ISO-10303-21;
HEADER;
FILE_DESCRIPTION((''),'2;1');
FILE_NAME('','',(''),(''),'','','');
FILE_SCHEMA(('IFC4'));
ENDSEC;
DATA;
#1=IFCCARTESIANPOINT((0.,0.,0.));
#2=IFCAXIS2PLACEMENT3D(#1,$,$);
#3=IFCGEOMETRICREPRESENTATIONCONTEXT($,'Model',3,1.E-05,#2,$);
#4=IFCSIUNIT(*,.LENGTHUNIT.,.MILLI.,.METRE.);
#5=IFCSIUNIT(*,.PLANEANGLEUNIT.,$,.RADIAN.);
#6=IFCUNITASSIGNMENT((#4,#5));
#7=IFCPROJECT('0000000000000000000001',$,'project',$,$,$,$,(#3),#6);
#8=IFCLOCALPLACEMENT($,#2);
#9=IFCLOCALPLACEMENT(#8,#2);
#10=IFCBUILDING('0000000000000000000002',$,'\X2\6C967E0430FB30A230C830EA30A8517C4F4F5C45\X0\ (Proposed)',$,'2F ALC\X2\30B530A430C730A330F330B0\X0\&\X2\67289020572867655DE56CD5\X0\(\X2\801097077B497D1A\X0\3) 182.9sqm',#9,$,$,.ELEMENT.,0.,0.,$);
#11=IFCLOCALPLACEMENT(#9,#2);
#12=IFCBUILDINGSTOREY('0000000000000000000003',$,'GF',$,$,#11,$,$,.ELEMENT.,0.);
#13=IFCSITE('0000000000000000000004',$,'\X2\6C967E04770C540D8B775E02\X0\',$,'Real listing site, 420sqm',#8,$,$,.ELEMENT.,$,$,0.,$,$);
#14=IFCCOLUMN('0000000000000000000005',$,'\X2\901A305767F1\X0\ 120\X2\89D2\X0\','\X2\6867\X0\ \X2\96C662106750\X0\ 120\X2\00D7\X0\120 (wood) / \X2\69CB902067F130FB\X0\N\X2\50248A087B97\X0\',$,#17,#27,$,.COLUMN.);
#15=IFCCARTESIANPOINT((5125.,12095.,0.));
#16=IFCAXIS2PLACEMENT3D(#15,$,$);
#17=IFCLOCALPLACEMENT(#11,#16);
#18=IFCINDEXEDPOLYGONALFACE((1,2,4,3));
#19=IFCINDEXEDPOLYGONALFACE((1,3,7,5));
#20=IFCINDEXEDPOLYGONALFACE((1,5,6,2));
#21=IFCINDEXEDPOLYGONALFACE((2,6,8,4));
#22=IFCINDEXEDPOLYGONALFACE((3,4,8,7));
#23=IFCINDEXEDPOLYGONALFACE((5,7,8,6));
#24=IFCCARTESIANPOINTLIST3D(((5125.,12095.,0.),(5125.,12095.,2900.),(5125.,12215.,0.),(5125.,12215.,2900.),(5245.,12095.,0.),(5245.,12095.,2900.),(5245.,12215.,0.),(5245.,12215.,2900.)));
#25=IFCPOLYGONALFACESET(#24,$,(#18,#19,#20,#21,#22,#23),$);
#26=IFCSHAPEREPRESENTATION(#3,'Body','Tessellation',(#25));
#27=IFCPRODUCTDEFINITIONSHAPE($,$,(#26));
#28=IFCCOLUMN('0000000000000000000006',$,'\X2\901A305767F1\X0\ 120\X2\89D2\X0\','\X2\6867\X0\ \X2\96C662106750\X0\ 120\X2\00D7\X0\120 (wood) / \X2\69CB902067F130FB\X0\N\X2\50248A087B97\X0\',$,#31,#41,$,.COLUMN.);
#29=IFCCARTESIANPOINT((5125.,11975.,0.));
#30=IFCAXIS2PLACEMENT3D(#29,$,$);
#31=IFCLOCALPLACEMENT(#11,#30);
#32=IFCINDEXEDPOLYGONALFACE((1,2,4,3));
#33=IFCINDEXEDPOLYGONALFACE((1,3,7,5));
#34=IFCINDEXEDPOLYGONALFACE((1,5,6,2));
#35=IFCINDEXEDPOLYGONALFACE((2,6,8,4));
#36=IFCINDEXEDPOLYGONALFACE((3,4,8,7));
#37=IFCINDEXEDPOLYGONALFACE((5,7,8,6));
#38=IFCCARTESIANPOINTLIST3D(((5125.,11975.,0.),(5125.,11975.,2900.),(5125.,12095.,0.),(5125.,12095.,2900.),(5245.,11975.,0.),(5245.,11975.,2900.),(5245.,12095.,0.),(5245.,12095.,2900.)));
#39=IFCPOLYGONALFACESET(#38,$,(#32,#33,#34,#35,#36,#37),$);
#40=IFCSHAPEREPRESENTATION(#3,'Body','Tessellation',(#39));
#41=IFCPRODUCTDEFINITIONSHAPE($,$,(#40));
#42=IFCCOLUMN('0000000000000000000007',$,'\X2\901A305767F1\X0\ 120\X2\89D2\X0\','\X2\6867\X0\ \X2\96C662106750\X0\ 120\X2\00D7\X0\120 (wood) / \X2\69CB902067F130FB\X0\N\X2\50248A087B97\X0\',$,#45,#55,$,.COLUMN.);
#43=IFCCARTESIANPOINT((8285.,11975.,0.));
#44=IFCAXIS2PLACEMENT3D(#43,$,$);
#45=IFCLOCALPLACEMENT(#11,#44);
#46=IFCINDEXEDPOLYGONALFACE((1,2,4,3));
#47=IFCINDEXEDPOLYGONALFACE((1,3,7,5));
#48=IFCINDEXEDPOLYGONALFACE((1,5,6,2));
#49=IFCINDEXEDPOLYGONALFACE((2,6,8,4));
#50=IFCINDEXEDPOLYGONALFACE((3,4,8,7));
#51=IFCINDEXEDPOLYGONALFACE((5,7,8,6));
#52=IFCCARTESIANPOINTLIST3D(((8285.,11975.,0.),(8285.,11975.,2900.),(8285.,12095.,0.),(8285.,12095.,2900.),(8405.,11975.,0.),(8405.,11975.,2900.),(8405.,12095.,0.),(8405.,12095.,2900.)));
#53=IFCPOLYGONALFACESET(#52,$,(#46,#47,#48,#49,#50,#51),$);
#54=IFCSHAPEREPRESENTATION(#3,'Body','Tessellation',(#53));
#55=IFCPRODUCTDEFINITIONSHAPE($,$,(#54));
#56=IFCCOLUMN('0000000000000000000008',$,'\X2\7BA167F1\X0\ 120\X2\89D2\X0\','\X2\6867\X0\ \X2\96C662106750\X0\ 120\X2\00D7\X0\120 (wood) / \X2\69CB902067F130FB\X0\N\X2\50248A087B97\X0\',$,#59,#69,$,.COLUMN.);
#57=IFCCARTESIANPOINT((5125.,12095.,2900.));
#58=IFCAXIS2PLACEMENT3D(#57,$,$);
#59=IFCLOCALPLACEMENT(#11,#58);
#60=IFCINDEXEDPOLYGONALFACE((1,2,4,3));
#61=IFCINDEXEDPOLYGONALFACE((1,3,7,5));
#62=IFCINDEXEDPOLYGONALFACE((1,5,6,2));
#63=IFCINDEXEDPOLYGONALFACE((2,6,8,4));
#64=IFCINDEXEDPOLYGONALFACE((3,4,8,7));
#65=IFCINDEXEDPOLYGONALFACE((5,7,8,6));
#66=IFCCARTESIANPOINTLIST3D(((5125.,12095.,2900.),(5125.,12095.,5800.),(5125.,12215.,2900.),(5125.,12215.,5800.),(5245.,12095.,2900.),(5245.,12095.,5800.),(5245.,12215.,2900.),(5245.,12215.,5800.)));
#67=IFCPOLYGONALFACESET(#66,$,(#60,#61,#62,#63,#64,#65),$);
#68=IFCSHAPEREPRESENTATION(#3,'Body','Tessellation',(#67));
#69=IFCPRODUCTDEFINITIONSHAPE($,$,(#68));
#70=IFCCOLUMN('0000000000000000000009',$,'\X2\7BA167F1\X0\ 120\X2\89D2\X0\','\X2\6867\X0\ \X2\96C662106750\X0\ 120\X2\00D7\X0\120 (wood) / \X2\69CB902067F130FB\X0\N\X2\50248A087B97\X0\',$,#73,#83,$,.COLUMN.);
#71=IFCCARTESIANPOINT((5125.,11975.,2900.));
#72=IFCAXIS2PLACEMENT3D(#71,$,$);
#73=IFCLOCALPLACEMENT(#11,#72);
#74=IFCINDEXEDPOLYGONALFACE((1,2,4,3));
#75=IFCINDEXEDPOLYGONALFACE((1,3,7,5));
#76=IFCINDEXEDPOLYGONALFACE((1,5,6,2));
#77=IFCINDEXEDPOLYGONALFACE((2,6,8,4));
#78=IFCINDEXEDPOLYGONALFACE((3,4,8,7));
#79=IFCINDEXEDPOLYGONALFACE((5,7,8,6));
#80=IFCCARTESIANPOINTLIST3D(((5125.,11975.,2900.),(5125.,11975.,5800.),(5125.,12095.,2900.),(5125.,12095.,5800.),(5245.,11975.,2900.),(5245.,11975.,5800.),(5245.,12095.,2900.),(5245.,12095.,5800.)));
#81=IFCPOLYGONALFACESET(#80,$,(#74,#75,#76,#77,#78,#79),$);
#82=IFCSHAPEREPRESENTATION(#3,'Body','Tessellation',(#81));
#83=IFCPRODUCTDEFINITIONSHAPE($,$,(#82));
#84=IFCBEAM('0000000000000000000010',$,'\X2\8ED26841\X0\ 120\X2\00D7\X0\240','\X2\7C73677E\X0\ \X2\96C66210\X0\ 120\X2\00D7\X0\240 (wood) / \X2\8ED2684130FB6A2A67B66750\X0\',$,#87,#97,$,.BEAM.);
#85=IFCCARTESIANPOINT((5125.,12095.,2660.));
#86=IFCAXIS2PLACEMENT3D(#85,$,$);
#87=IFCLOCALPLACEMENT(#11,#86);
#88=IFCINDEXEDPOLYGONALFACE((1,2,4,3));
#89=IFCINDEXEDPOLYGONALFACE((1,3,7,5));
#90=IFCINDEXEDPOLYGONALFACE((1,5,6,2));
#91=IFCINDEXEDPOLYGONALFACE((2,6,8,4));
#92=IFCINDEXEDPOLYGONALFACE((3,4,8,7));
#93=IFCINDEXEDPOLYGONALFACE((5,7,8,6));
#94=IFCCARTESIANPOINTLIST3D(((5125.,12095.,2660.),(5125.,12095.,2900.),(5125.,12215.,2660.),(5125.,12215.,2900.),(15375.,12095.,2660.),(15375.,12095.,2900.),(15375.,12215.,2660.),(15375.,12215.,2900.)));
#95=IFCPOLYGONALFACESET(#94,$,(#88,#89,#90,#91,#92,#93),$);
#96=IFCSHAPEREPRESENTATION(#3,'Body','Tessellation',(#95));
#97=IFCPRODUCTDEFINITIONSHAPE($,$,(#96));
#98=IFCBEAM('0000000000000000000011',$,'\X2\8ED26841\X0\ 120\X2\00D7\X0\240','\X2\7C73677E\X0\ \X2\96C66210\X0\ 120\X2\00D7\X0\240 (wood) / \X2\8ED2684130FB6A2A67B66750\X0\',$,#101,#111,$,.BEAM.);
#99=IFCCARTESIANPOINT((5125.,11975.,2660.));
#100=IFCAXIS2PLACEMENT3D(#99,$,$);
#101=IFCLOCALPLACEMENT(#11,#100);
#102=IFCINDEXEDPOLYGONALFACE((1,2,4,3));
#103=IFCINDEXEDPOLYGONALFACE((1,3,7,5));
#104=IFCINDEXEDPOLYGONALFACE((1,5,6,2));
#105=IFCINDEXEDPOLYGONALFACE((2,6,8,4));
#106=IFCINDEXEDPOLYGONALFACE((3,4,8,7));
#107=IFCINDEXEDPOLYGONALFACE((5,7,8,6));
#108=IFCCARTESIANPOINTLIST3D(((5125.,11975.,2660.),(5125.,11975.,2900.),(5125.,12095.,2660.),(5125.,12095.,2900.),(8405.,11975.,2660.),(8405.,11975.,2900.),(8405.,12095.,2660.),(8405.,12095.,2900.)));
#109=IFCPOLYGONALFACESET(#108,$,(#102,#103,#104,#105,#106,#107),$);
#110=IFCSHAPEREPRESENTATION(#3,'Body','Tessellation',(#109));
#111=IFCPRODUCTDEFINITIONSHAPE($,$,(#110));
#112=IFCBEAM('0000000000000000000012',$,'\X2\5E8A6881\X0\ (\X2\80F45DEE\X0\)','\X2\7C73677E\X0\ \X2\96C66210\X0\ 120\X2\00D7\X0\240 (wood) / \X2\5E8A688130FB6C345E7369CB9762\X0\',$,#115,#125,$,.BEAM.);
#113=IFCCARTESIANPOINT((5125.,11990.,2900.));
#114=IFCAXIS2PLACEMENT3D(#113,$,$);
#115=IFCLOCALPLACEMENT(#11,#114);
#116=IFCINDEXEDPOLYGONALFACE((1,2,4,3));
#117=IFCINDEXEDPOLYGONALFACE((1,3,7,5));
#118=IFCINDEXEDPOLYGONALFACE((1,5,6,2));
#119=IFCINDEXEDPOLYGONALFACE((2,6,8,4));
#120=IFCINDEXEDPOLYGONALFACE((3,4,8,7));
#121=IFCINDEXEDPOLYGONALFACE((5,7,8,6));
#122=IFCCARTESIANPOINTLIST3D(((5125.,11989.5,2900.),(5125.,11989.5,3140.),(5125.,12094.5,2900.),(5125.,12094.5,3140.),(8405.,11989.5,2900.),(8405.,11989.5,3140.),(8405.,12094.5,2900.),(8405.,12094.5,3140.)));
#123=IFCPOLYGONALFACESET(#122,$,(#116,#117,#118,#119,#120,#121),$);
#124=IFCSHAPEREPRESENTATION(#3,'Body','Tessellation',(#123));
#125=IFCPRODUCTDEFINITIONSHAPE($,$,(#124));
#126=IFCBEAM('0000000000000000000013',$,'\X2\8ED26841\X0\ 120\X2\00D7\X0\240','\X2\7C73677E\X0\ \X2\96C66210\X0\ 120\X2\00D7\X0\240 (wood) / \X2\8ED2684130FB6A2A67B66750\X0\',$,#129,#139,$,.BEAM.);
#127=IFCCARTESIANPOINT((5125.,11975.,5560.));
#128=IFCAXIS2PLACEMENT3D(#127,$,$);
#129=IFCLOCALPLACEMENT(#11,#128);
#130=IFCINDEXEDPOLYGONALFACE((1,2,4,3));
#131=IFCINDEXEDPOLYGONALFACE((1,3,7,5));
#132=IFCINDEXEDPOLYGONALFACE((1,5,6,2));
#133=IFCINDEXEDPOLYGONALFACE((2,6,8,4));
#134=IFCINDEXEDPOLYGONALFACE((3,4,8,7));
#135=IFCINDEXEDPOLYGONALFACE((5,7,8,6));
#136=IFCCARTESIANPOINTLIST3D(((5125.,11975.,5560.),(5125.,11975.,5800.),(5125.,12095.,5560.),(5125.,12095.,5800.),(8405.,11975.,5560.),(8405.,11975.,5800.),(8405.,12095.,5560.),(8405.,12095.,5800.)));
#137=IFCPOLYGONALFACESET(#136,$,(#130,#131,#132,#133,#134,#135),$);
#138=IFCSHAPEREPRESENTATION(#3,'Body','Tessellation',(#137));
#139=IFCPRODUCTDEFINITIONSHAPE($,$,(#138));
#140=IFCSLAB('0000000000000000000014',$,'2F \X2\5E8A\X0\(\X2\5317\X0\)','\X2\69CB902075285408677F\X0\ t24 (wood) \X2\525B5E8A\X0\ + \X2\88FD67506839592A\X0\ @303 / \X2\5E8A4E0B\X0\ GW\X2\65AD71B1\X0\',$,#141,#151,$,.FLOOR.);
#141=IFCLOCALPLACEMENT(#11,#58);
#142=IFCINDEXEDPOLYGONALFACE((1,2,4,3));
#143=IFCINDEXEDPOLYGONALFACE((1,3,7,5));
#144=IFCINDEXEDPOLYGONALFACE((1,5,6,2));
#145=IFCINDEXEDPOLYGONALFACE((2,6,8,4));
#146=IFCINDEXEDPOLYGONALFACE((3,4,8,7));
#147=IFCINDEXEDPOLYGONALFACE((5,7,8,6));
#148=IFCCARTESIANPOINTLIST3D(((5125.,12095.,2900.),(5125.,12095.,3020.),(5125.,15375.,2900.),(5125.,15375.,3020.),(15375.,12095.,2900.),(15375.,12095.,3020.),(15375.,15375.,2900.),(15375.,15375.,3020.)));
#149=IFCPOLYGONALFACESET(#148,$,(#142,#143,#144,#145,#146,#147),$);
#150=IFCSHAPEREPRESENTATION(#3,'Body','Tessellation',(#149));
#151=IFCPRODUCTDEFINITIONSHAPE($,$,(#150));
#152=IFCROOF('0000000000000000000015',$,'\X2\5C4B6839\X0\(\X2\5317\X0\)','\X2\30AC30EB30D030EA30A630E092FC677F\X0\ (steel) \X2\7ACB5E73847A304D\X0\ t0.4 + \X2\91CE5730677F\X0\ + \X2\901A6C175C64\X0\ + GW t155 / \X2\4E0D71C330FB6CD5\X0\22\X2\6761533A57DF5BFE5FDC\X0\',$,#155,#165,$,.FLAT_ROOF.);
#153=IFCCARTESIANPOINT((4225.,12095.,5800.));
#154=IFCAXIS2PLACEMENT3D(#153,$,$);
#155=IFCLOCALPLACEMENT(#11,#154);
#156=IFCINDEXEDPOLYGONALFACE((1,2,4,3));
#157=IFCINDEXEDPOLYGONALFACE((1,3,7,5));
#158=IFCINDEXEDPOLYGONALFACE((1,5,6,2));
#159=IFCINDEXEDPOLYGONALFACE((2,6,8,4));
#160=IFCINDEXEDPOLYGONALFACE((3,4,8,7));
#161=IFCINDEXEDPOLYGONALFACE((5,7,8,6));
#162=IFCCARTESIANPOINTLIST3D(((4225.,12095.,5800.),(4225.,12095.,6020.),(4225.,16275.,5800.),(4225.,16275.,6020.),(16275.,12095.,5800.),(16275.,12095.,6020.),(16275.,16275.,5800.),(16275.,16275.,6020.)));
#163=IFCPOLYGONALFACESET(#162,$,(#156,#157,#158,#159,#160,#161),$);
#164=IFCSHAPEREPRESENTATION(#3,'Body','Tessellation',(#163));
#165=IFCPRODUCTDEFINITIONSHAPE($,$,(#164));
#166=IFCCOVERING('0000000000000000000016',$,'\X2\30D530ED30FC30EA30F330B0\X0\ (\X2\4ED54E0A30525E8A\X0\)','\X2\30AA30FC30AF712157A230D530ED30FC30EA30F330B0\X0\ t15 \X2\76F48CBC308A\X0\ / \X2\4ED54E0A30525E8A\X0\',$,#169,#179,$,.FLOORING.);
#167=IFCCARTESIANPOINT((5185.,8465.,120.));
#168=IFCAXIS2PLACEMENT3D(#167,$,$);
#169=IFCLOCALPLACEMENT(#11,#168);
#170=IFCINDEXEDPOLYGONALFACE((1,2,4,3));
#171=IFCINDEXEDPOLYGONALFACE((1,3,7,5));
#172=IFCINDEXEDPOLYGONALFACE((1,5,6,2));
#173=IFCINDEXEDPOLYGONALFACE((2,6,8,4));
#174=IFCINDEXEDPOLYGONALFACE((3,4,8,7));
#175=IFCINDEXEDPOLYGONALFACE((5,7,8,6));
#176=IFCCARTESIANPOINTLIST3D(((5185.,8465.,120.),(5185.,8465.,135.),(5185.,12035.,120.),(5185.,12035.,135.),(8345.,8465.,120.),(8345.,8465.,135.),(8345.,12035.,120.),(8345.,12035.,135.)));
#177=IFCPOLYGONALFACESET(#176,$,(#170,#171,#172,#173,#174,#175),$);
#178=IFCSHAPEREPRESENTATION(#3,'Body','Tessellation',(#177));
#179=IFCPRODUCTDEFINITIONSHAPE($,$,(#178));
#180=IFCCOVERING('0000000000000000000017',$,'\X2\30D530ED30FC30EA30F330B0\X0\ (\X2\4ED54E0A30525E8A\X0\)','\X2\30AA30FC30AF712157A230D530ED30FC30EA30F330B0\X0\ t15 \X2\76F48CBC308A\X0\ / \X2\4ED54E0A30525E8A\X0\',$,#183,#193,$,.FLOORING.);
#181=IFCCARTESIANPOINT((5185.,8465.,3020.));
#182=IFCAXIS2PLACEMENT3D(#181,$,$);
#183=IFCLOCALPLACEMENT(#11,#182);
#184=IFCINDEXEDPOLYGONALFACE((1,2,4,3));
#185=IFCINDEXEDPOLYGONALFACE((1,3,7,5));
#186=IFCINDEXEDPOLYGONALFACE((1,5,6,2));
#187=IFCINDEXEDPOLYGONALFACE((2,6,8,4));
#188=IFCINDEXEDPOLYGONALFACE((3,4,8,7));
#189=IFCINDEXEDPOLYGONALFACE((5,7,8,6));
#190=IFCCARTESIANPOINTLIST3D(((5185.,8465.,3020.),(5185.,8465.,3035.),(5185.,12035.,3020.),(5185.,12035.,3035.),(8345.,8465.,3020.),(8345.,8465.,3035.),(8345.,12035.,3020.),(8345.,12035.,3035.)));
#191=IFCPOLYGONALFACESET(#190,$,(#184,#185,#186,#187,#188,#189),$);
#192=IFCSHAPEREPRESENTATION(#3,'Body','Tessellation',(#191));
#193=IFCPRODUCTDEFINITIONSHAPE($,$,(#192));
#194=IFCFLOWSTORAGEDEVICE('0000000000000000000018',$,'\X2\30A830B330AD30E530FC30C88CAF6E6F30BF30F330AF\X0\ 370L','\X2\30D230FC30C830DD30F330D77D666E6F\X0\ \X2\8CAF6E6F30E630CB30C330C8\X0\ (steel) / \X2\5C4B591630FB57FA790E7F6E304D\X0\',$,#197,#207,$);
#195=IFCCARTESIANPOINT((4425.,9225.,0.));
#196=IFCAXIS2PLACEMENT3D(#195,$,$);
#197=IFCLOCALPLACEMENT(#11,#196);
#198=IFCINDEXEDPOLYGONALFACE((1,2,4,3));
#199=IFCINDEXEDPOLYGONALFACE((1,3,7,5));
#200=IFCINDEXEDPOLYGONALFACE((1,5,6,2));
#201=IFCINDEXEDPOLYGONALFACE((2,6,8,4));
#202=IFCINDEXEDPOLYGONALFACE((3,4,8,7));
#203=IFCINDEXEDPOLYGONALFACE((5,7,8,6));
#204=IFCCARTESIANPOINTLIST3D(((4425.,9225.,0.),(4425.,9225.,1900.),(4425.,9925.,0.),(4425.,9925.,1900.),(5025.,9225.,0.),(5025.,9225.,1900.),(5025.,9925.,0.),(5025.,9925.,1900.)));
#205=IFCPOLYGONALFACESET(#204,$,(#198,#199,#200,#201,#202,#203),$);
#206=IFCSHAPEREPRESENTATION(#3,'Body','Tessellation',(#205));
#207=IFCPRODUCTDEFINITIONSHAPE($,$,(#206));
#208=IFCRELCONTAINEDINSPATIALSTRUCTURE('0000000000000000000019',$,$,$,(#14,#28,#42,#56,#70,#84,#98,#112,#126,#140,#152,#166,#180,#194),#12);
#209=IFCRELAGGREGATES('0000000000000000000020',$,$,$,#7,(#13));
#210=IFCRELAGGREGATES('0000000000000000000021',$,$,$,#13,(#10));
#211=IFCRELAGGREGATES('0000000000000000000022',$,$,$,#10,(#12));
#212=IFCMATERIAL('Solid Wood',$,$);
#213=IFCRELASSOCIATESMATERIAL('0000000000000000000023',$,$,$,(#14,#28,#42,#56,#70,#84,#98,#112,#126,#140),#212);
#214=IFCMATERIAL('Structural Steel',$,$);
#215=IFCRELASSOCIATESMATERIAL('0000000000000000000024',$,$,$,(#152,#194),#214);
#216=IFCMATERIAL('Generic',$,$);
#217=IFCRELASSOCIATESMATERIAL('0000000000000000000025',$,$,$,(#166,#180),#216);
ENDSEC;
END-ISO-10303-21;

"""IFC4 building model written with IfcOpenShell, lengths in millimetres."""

from ifc_helpers import new_model, si_unit, frame, frame_2d, origin, place, context, project, spatial, rectangle, extrude, material, element, save


model = new_model("IFC4")

# Units and contexts
model_context = context("Model", 3, precision=1e-05, world=origin())
ifc_project = project(units=[si_unit("LENGTHUNIT", "METRE", prefix="MILLI"), si_unit("PLANEANGLEUNIT", "RADIAN")], contexts=[model_context])

# Site, building, storey
site_placement = place(None, origin())
site = spatial("IfcSite", under=ifc_project, at=site_placement, Name="沖縄県名護市", ObjectType="Real listing site, 420sqm", CompositionType="ELEMENT", RefElevation=0.0)
building_placement = place(site_placement, origin())
building = spatial("IfcBuilding", under=site, at=building_placement, Name="沖縄・アトリエ兼住居 (Proposed)", ObjectType="2F ALCサイディング&木造在来工法(耐震等級3) 182.9sqm", CompositionType="ELEMENT", ElevationOfRefHeight=0.0, ElevationOfTerrain=0.0)
storey_placement = place(building_placement, origin())
storey = spatial("IfcBuildingStorey", under=building, at=storey_placement, Name="GF", CompositionType="ELEMENT", Elevation=0.0)

# Columns
ifc_material_1 = material(Name="Solid Wood")
column_1_placement = place(storey_placement, frame((5125.0, 12095.0, 0.0)))
element("IfcColumn", 1, at=column_1_placement, inside=storey, material=ifc_material_1, Name="通し柱 120角", Description="桧 集成材 120×120 (wood) / 構造柱・N値計算", PredefinedType="COLUMN", context=model_context, shape_type="SweptSolid", body=[
    extrude(rectangle(XDim=120.0, YDim=120.0, at=frame_2d((60.0, 60.0))), frame((5125.0, 12095.0, 0.0)), (0.0, 0.0, 1.0), 2900.0),
])
column_2_placement = place(storey_placement, frame((5125.0, 11975.0, 0.0)))
element("IfcColumn", 2, at=column_2_placement, inside=storey, material=ifc_material_1, Name="通し柱 120角", Description="桧 集成材 120×120 (wood) / 構造柱・N値計算", PredefinedType="COLUMN", context=model_context, shape_type="SweptSolid", body=[
    extrude(rectangle(XDim=120.0, YDim=120.0, at=frame_2d((60.0, 60.0))), frame((5125.0, 11975.0, 0.0)), (0.0, 0.0, 1.0), 2900.0),
])
column_3_placement = place(storey_placement, frame((8285.0, 11975.0, 0.0)))
element("IfcColumn", 3, at=column_3_placement, inside=storey, material=ifc_material_1, Name="通し柱 120角", Description="桧 集成材 120×120 (wood) / 構造柱・N値計算", PredefinedType="COLUMN", context=model_context, shape_type="SweptSolid", body=[
    extrude(rectangle(XDim=120.0, YDim=120.0, at=frame_2d((60.0, 60.0))), frame((8285.0, 11975.0, 0.0)), (0.0, 0.0, 1.0), 2900.0),
])
column_4_placement = place(storey_placement, frame((5125.0, 12095.0, 2900.0)))
element("IfcColumn", 4, at=column_4_placement, inside=storey, material=ifc_material_1, Name="管柱 120角", Description="桧 集成材 120×120 (wood) / 構造柱・N値計算", PredefinedType="COLUMN", context=model_context, shape_type="SweptSolid", body=[
    extrude(rectangle(XDim=120.0, YDim=120.0, at=frame_2d((60.0, 60.0))), frame((5125.0, 12095.0, 2900.0)), (0.0, 0.0, 1.0), 2900.0),
])
column_5_placement = place(storey_placement, frame((5125.0, 11975.0, 2900.0)))
element("IfcColumn", 5, at=column_5_placement, inside=storey, material=ifc_material_1, Name="管柱 120角", Description="桧 集成材 120×120 (wood) / 構造柱・N値計算", PredefinedType="COLUMN", context=model_context, shape_type="SweptSolid", body=[
    extrude(rectangle(XDim=120.0, YDim=120.0, at=frame_2d((60.0, 60.0))), frame((5125.0, 11975.0, 2900.0)), (0.0, 0.0, 1.0), 2900.0),
])

# Beams
beam_1_placement = place(storey_placement, frame((5125.0, 12095.0, 2660.0)))
element("IfcBeam", 6, at=beam_1_placement, inside=storey, material=ifc_material_1, Name="軒桁 120×240", Description="米松 集成 120×240 (wood) / 軒桁・横架材", PredefinedType="BEAM", context=model_context, shape_type="SweptSolid", body=[
    extrude(rectangle(XDim=10250.0, YDim=120.0, at=frame_2d((5125.0, 60.0))), frame((5125.0, 12095.0, 2660.0)), (0.0, 0.0, 1.0), 240.0),
])
beam_2_placement = place(storey_placement, frame((5125.0, 11975.0, 2660.0)))
element("IfcBeam", 7, at=beam_2_placement, inside=storey, material=ifc_material_1, Name="軒桁 120×240", Description="米松 集成 120×240 (wood) / 軒桁・横架材", PredefinedType="BEAM", context=model_context, shape_type="SweptSolid", body=[
    extrude(rectangle(XDim=3280.0, YDim=120.0, at=frame_2d((1640.0, 60.0))), frame((5125.0, 11975.0, 2660.0)), (0.0, 0.0, 1.0), 240.0),
])
beam_3_placement = place(storey_placement, frame((5125.0, 11990.0, 2900.0)))
element("IfcBeam", 8, at=beam_3_placement, inside=storey, material=ifc_material_1, Name="床梁 (胴差)", Description="米松 集成 120×240 (wood) / 床梁・水平構面", PredefinedType="BEAM", context=model_context, shape_type="SweptSolid", body=[
    extrude(rectangle(XDim=3280.0, YDim=105.0, at=frame_2d((1640.0, 52.0))), frame((5125.0, 11990.0, 2900.0)), (0.0, 0.0, 1.0), 240.0),
])
beam_4_placement = place(storey_placement, frame((5125.0, 11975.0, 5560.0)))
element("IfcBeam", 9, at=beam_4_placement, inside=storey, material=ifc_material_1, Name="軒桁 120×240", Description="米松 集成 120×240 (wood) / 軒桁・横架材", PredefinedType="BEAM", context=model_context, shape_type="SweptSolid", body=[
    extrude(rectangle(XDim=3280.0, YDim=120.0, at=frame_2d((1640.0, 60.0))), frame((5125.0, 11975.0, 5560.0)), (0.0, 0.0, 1.0), 240.0),
])

# Slab
slab_1_placement = place(storey_placement, frame((5125.0, 12095.0, 2900.0)))
element("IfcSlab", 10, at=slab_1_placement, inside=storey, material=ifc_material_1, Name="2F 床(北)", Description="構造用合板 t24 (wood) 剛床 + 製材根太 @303 / 床下 GW断熱", PredefinedType="FLOOR", context=model_context, shape_type="SweptSolid", body=[
    extrude(rectangle(XDim=10250.0, YDim=3280.0, at=frame_2d((5125.0, 1640.0))), frame((5125.0, 12095.0, 2900.0)), (0.0, 0.0, 1.0), 120.0),
])

# Roof
ifc_material_2 = material(Name="Structural Steel")
for number, where, name in (
    (11, (4225.0, 12095.0, 5800.0), "屋根(北)"),
):
    element("IfcRoof", number, at=place(storey_placement, frame(where)), inside=storey, material=ifc_material_2, Name=name, Description="ガルバリウム鋼板 (steel) 立平葺き t0.4 + 野地板 + 通気層 + GW t155 / 不燃・法22条区域対応", PredefinedType="FLAT_ROOF", context=model_context, shape_type="SweptSolid", body=[
        extrude(rectangle(XDim=12050.0, YDim=4180.0, at=frame_2d((6025.0, 2090.0))), frame((4225.0, 12095.0, 5800.0)), (0.0, 0.0, 1.0), 220.0),
    ])

# Coverings
ifc_material_3 = material(Name="Generic")
covering_1_placement = place(storey_placement, frame((5185.0, 8465.0, 120.0)))
element("IfcCovering", 12, at=covering_1_placement, inside=storey, material=ifc_material_3, Name="フローリング (仕上げ床)", Description="オーク無垢フローリング t15 直貼り / 仕上げ床", PredefinedType="FLOORING", context=model_context, shape_type="SweptSolid", body=[
    extrude(rectangle(XDim=3160.0, YDim=3570.0, at=frame_2d((1580.0, 1785.0))), frame((5185.0, 8465.0, 120.0)), (0.0, 0.0, 1.0), 15.0),
])
covering_2_placement = place(storey_placement, frame((5185.0, 8465.0, 3020.0)))
element("IfcCovering", 13, at=covering_2_placement, inside=storey, material=ifc_material_3, Name="フローリング (仕上げ床)", Description="オーク無垢フローリング t15 直貼り / 仕上げ床", PredefinedType="FLOORING", context=model_context, shape_type="SweptSolid", body=[
    extrude(rectangle(XDim=3160.0, YDim=3570.0, at=frame_2d((1580.0, 1785.0))), frame((5185.0, 8465.0, 3020.0)), (0.0, 0.0, 1.0), 15.0),
])

# Flow storage device
flow_storage_device_placement = place(storey_placement, frame((4425.0, 9225.0, 0.0)))
element("IfcFlowStorageDevice", 14, at=flow_storage_device_placement, inside=storey, material=ifc_material_2, Name="エコキュート貯湯タンク 370L", Description="ヒートポンプ給湯 貯湯ユニット (steel) / 屋外・基礎置き", context=model_context, shape_type="SweptSolid", body=[
    extrude(rectangle(XDim=600.0, YDim=700.0, at=frame_2d((300.0, 350.0))), frame((4425.0, 9225.0, 0.0)), (0.0, 0.0, 1.0), 1900.0),
])

save(model, "model.ifc")
